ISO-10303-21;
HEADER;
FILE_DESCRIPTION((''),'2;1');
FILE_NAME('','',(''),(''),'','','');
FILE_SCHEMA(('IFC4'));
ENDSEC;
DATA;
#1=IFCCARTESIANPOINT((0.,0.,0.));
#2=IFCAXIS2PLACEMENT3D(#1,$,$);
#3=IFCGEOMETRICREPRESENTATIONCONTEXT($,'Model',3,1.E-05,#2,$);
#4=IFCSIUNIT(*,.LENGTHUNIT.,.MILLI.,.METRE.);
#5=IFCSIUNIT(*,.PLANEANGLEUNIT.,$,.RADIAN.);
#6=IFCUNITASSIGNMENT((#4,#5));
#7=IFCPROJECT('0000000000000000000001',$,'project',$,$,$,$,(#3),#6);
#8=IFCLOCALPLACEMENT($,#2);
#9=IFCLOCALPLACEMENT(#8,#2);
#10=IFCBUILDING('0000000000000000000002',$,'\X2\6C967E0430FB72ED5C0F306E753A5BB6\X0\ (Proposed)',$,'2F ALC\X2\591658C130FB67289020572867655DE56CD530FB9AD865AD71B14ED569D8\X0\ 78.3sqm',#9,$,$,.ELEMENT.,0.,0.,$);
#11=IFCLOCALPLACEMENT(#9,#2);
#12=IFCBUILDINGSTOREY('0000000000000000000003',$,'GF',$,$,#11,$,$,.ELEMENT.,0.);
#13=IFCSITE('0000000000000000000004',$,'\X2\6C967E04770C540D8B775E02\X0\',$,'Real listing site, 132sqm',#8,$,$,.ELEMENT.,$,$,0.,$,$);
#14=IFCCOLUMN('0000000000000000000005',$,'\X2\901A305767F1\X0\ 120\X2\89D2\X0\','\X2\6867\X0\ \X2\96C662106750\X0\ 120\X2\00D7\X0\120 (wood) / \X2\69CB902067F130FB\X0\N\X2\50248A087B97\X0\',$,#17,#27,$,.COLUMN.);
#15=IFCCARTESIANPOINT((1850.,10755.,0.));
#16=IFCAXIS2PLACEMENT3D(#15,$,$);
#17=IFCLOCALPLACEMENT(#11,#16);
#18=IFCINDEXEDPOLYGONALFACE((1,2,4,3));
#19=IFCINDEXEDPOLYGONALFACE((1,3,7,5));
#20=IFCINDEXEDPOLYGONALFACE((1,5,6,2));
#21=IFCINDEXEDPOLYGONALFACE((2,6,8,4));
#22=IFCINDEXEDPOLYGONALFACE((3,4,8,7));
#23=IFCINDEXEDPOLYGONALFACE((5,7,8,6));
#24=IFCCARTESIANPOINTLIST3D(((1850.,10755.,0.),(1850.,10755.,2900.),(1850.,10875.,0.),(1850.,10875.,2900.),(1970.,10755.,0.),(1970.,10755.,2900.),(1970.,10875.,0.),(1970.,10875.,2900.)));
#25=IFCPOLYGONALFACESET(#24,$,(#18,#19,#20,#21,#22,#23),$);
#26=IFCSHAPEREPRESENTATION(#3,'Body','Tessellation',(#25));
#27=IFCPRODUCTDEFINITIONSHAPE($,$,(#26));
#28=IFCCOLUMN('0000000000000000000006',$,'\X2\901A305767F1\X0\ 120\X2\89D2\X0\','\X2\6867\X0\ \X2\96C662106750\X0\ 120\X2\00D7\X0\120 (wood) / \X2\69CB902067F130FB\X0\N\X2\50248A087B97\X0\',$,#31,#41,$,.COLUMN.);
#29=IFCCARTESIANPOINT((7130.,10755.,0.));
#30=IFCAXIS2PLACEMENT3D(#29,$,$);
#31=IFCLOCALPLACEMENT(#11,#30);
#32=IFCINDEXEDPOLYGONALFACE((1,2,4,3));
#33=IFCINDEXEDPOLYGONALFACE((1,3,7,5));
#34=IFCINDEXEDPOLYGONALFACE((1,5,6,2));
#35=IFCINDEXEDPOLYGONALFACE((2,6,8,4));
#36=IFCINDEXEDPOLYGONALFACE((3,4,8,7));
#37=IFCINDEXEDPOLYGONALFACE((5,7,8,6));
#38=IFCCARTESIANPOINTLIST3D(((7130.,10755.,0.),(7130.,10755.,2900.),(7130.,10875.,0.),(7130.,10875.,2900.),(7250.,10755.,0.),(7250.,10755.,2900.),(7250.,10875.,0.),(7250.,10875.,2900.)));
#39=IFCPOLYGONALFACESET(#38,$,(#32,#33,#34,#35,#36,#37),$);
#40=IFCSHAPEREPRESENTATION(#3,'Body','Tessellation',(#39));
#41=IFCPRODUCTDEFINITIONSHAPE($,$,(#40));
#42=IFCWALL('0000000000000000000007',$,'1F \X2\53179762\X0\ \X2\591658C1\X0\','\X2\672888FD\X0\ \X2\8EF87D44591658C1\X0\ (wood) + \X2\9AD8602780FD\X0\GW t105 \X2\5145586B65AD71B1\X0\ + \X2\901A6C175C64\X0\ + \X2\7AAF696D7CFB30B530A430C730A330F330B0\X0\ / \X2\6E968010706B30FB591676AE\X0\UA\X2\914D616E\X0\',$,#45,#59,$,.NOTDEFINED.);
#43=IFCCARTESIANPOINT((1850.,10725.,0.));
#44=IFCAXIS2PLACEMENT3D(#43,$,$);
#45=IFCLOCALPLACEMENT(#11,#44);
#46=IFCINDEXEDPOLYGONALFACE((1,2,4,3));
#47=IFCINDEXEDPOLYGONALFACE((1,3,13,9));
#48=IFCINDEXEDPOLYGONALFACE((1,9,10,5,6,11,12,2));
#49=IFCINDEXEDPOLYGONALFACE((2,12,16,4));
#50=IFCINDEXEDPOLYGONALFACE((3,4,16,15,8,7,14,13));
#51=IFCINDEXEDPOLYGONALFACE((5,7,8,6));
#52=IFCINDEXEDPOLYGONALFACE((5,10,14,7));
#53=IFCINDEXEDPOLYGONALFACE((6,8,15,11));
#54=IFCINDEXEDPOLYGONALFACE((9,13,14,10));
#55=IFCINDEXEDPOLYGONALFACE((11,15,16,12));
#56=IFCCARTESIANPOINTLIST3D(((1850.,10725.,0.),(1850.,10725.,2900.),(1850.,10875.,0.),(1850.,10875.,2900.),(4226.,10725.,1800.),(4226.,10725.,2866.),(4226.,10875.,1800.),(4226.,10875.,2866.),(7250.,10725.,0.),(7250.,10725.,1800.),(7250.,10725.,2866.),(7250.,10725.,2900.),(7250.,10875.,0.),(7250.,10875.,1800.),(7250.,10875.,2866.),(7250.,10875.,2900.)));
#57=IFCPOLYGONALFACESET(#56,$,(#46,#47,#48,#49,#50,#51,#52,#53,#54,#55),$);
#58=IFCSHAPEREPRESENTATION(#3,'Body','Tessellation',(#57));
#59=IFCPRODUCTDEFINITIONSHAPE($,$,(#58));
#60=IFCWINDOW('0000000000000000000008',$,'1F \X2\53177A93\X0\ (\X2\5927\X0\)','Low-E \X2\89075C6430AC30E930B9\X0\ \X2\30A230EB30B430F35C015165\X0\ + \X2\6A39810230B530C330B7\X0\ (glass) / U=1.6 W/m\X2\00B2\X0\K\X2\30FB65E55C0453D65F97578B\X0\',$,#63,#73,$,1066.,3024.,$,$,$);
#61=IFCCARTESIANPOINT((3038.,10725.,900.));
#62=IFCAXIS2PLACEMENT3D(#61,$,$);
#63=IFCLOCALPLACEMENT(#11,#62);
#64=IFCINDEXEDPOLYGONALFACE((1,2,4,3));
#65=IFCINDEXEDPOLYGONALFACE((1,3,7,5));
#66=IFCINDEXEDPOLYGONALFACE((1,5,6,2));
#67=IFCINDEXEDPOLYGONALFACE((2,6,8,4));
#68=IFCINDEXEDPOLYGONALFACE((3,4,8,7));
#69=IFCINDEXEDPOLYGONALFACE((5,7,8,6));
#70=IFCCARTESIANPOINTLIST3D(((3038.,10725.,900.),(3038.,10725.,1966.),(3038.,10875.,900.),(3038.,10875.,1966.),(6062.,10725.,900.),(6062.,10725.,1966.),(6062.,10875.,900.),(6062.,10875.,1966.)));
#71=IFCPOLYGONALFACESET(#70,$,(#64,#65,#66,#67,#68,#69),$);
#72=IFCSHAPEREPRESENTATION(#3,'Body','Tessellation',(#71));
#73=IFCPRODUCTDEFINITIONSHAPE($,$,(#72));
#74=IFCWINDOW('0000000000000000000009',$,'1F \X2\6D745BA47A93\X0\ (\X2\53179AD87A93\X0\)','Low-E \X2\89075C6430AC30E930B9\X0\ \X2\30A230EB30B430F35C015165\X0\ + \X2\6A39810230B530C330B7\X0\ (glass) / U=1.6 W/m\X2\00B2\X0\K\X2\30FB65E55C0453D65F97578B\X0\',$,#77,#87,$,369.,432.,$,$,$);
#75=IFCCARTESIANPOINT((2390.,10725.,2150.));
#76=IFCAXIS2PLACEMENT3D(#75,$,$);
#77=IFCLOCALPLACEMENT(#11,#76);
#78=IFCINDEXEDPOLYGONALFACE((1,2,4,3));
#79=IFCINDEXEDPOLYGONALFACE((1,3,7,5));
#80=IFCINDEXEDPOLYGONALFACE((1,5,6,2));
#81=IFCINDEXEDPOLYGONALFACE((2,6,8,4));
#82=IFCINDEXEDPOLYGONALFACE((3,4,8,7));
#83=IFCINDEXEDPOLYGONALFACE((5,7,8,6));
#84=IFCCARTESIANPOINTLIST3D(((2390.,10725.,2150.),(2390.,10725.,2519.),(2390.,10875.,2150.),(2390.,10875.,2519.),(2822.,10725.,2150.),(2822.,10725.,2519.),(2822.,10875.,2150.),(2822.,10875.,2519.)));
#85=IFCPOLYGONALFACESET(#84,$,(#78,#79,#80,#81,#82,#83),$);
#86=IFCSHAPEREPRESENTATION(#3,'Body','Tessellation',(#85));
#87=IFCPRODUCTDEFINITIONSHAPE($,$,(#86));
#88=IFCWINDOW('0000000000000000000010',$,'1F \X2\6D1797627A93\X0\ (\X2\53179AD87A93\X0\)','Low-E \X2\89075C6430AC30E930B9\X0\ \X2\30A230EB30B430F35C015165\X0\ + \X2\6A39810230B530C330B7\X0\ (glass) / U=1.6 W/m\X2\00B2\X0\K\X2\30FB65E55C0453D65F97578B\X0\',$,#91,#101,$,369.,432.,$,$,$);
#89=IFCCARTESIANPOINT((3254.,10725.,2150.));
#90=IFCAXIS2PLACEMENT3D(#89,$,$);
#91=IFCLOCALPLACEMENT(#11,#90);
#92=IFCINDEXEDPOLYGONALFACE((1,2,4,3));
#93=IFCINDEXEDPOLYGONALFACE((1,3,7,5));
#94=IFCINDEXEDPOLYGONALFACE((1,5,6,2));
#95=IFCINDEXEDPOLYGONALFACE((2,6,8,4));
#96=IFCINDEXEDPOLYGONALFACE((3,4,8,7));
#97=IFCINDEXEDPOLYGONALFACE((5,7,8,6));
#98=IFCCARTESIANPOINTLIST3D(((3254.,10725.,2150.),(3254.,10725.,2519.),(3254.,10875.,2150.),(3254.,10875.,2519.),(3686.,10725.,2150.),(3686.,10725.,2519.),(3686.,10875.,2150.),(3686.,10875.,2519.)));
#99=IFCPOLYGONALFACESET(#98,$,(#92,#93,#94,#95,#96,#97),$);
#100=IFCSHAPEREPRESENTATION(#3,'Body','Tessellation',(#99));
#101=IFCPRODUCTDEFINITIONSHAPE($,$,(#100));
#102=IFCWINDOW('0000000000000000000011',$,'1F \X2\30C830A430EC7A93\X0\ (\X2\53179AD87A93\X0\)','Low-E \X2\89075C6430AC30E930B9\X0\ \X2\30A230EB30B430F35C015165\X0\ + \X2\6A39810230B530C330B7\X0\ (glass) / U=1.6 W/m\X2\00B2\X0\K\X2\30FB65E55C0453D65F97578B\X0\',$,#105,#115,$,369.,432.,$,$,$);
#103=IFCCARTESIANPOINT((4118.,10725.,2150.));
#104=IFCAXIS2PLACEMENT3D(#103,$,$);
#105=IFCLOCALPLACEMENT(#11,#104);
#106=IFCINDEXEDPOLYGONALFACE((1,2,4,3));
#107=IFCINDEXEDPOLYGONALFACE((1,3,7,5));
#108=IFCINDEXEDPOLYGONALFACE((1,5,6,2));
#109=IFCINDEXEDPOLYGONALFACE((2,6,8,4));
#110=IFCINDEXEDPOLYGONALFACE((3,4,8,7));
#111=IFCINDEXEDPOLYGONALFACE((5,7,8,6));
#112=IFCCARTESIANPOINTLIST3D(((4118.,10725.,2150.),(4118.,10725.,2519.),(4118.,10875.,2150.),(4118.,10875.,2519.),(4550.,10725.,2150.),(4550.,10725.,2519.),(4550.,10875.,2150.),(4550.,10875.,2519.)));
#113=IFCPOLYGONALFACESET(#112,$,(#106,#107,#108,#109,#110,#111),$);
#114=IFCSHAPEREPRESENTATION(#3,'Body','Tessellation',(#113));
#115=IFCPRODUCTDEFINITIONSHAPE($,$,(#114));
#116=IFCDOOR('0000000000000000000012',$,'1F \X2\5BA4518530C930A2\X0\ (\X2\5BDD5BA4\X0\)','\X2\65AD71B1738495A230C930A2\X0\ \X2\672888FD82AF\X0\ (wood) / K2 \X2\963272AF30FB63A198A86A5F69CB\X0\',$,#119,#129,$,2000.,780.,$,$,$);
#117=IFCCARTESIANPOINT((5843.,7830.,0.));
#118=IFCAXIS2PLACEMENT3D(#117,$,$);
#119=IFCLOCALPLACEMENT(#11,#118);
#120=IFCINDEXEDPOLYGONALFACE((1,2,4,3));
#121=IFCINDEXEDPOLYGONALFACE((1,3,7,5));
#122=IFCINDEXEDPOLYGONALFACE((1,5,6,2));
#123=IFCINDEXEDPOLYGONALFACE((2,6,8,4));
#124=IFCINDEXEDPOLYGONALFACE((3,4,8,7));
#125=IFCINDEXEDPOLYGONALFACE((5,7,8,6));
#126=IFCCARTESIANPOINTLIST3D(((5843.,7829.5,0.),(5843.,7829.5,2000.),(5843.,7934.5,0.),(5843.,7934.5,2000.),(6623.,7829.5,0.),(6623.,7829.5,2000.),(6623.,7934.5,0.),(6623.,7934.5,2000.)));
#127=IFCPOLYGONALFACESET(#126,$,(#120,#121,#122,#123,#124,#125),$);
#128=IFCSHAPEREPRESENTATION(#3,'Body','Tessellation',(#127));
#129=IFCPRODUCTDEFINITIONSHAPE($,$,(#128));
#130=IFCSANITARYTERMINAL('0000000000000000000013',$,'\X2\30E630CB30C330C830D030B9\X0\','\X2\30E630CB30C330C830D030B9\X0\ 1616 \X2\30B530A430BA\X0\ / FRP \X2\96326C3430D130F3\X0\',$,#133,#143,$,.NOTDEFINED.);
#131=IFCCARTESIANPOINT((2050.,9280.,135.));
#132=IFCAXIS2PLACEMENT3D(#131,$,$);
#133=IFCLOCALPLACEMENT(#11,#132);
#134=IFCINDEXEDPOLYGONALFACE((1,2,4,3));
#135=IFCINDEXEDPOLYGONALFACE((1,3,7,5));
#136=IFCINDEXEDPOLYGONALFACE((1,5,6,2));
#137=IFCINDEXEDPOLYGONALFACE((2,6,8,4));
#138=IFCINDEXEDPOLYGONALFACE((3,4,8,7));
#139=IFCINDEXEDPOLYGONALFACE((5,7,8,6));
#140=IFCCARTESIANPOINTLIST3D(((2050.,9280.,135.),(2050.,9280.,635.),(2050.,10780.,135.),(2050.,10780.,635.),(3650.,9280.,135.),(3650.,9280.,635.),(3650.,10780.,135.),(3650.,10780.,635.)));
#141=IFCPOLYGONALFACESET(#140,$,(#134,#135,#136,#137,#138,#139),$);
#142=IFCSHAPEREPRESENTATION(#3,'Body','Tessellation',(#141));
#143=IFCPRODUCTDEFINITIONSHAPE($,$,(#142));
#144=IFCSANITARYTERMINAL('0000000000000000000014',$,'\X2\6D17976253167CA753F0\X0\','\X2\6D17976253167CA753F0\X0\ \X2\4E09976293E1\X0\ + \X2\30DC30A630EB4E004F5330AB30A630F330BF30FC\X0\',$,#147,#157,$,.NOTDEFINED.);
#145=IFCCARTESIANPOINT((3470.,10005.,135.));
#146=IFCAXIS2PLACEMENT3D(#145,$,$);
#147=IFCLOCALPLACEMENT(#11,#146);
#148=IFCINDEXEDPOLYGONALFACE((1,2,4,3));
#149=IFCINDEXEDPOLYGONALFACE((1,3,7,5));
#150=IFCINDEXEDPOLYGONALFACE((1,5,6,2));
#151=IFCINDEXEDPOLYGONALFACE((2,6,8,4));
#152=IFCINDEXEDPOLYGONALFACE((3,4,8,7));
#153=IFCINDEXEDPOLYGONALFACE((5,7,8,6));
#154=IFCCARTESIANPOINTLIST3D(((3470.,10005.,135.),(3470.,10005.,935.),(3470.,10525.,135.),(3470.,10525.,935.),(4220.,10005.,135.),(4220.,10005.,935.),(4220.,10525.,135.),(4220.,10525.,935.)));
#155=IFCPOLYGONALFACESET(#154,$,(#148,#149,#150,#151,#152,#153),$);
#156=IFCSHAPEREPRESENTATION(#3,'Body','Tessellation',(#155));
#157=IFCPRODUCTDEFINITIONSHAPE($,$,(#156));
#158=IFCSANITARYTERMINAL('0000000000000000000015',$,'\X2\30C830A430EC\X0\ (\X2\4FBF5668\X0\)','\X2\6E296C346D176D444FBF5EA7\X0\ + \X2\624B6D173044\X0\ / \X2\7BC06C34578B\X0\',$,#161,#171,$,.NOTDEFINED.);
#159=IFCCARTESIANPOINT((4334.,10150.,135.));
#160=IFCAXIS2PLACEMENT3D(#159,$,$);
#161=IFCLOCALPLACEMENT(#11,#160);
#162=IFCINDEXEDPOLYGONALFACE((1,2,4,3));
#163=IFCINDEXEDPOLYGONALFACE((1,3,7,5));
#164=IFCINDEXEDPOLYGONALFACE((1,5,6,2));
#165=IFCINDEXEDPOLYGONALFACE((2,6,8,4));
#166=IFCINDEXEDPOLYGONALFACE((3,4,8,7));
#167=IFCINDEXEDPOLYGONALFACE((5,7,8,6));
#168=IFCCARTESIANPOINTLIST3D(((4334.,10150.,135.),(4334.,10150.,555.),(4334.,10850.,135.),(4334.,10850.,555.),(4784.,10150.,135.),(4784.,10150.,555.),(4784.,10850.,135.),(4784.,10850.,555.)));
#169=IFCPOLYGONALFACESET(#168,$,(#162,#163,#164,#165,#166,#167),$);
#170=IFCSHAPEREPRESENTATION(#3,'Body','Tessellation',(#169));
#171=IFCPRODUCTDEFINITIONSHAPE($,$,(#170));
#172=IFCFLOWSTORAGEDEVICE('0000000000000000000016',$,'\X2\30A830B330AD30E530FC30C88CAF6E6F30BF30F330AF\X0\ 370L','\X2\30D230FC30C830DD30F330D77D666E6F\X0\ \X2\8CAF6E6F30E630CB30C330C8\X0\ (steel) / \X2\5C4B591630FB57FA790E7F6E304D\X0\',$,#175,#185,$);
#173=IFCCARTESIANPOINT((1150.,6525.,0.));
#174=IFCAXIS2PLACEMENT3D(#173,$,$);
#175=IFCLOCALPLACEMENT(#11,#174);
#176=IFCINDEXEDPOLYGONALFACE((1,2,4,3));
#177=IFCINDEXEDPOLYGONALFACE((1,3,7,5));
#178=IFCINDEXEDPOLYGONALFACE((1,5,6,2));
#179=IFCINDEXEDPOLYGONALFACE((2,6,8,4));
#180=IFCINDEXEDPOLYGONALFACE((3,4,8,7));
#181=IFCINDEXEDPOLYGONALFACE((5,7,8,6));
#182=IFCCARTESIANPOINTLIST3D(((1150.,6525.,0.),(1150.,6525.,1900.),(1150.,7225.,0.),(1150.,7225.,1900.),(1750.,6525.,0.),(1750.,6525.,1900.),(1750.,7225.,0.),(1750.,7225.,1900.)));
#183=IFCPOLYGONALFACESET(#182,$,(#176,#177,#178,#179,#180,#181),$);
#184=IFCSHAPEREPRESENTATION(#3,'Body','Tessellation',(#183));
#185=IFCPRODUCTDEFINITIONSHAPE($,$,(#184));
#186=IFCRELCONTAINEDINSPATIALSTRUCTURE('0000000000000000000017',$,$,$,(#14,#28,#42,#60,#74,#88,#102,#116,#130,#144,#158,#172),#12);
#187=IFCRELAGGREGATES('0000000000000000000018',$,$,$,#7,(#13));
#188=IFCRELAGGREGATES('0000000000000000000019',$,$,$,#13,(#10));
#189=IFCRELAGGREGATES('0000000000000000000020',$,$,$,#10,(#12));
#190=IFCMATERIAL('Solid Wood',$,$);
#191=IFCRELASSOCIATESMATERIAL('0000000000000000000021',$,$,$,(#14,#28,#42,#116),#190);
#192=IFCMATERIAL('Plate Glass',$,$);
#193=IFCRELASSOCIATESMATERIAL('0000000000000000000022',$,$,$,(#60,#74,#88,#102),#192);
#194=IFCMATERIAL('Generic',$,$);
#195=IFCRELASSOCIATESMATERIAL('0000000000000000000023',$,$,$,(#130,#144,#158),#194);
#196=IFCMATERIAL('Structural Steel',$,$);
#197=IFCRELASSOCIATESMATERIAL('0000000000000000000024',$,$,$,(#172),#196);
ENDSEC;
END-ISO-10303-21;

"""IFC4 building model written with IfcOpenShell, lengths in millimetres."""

from ifc_helpers import new_model, si_unit, frame, frame_2d, origin, place, context, project, spatial, rectangle, extrude, material, element, fill, save


model = new_model("IFC4")

# Units and contexts
model_context = context("Model", 3, precision=1e-05, world=origin())
ifc_project = project(units=[si_unit("LENGTHUNIT", "METRE", prefix="MILLI"), si_unit("PLANEANGLEUNIT", "RADIAN")], contexts=[model_context])

# Site, building, storey
site_placement = place(None, origin())
site = spatial("IfcSite", under=ifc_project, at=site_placement, Name="沖縄県名護市", ObjectType="Real listing site, 132sqm", CompositionType="ELEMENT", RefElevation=0.0)
building_placement = place(site_placement, origin())
building = spatial("IfcBuilding", under=site, at=building_placement, Name="沖縄・狭小の町家 (Proposed)", ObjectType="2F ALC外壁・木造在来工法・高断熱仕様 78.3sqm", CompositionType="ELEMENT", ElevationOfRefHeight=0.0, ElevationOfTerrain=0.0)
storey_placement = place(building_placement, origin())
storey = spatial("IfcBuildingStorey", under=building, at=storey_placement, Name="GF", CompositionType="ELEMENT", Elevation=0.0)

# Columns
ifc_material_1 = material(Name="Solid Wood")
column_1_placement = place(storey_placement, frame((1850.0, 10755.0, 0.0)))
element("IfcColumn", 1, at=column_1_placement, inside=storey, material=ifc_material_1, Name="通し柱 120角", Description="桧 集成材 120×120 (wood) / 構造柱・N値計算", PredefinedType="COLUMN", context=model_context, shape_type="SweptSolid", body=[
    extrude(rectangle(XDim=120.0, YDim=120.0, at=frame_2d((60.0, 60.0))), frame((1850.0, 10755.0, 0.0)), (0.0, 0.0, 1.0), 2900.0),
])
column_2_placement = place(storey_placement, frame((7130.0, 10755.0, 0.0)))
element("IfcColumn", 2, at=column_2_placement, inside=storey, material=ifc_material_1, Name="通し柱 120角", Description="桧 集成材 120×120 (wood) / 構造柱・N値計算", PredefinedType="COLUMN", context=model_context, shape_type="SweptSolid", body=[
    extrude(rectangle(XDim=120.0, YDim=120.0, at=frame_2d((60.0, 60.0))), frame((7130.0, 10755.0, 0.0)), (0.0, 0.0, 1.0), 2900.0),
])

# Wall, openings, windows
wall_1_placement = place(storey_placement, frame((1850.0, 10725.0, 0.0)))
wall_1 = element("IfcWall", 3, at=wall_1_placement, inside=storey, material=ifc_material_1, Name="1F 北面 外壁", Description="木製 軸組外壁 (wood) + 高性能GW t105 充填断熱 + 通気層 + 窯業系サイディング / 準耐火・外皮UA配慮", PredefinedType="NOTDEFINED", context=model_context, shape_type="SweptSolid", body=[
    extrude(rectangle(XDim=5400.0, YDim=150.0, at=frame_2d((2700.0, 75.0))), frame((1850.0, 10725.0, 0.0)), (0.0, 0.0, 1.0), 2900.0),
])
opening_1_placement = place(storey_placement, frame((3038.0, 10725.0, 900.0)))
opening_1 = element("IfcOpeningElement", 4, at=opening_1_placement, cuts=wall_1, PredefinedType="NOTDEFINED", context=model_context, shape_type="SweptSolid", body=[
    extrude(rectangle(XDim=3024.0, YDim=150.0, at=frame_2d((1512.0, 75.0))), frame((3038.0, 10725.0, 900.0)), (0.0, 0.0, 1.0), 1066.0),
])
opening_2_placement = place(storey_placement, frame((2390.0, 10725.0, 2150.0)))
opening_2 = element("IfcOpeningElement", 5, at=opening_2_placement, cuts=wall_1, PredefinedType="NOTDEFINED", context=model_context, shape_type="SweptSolid", body=[
    extrude(rectangle(XDim=432.0, YDim=150.0, at=frame_2d((216.0, 75.0))), frame((2390.0, 10725.0, 2150.0)), (0.0, 0.0, 1.0), 369.0),
])
opening_3_placement = place(storey_placement, frame((3254.0, 10725.0, 2150.0)))
opening_3 = element("IfcOpeningElement", 6, at=opening_3_placement, cuts=wall_1, PredefinedType="NOTDEFINED", context=model_context, shape_type="SweptSolid", body=[
    extrude(rectangle(XDim=432.0, YDim=150.0, at=frame_2d((216.0, 75.0))), frame((3254.0, 10725.0, 2150.0)), (0.0, 0.0, 1.0), 369.0),
])
opening_4_placement = place(storey_placement, frame((4118.0, 10725.0, 2150.0)))
opening_4 = element("IfcOpeningElement", 7, at=opening_4_placement, cuts=wall_1, PredefinedType="NOTDEFINED", context=model_context, shape_type="SweptSolid", body=[
    extrude(rectangle(XDim=432.0, YDim=150.0, at=frame_2d((216.0, 75.0))), frame((4118.0, 10725.0, 2150.0)), (0.0, 0.0, 1.0), 369.0),
])
ifc_material_2 = material(Name="Plate Glass")
window_1_placement = place(storey_placement, frame((3038.0, 10725.0, 900.0)))
window_1 = element("IfcWindow", 8, at=window_1_placement, inside=storey, material=ifc_material_2, Name="1F 北窓 (大)", Description="Low-E 複層ガラス アルゴン封入 + 樹脂サッシ (glass) / U=1.6 W/m²K・日射取得型", OverallHeight=1066.0, OverallWidth=3024.0, context=model_context, shape_type="SweptSolid", body=[
    extrude(rectangle(XDim=3024.0, YDim=150.0, at=frame_2d((1512.0, 75.0))), frame((3038.0, 10725.0, 900.0)), (0.0, 0.0, 1.0), 1066.0),
])
fill(opening_1, window_1)
window_2_placement = place(storey_placement, frame((2390.0, 10725.0, 2150.0)))
window_2 = element("IfcWindow", 9, at=window_2_placement, inside=storey, material=ifc_material_2, Name="1F 浴室窓 (北高窓)", Description="Low-E 複層ガラス アルゴン封入 + 樹脂サッシ (glass) / U=1.6 W/m²K・日射取得型", OverallHeight=369.0, OverallWidth=432.0, context=model_context, shape_type="SweptSolid", body=[
    extrude(rectangle(XDim=432.0, YDim=150.0, at=frame_2d((216.0, 75.0))), frame((2390.0, 10725.0, 2150.0)), (0.0, 0.0, 1.0), 369.0),
])
fill(opening_2, window_2)
window_3_placement = place(storey_placement, frame((3254.0, 10725.0, 2150.0)))
window_3 = element("IfcWindow", 10, at=window_3_placement, inside=storey, material=ifc_material_2, Name="1F 洗面窓 (北高窓)", Description="Low-E 複層ガラス アルゴン封入 + 樹脂サッシ (glass) / U=1.6 W/m²K・日射取得型", OverallHeight=369.0, OverallWidth=432.0, context=model_context, shape_type="SweptSolid", body=[
    extrude(rectangle(XDim=432.0, YDim=150.0, at=frame_2d((216.0, 75.0))), frame((3254.0, 10725.0, 2150.0)), (0.0, 0.0, 1.0), 369.0),
])
fill(opening_3, window_3)
window_4_placement = place(storey_placement, frame((4118.0, 10725.0, 2150.0)))
window_4 = element("IfcWindow", 11, at=window_4_placement, inside=storey, material=ifc_material_2, Name="1F トイレ窓 (北高窓)", Description="Low-E 複層ガラス アルゴン封入 + 樹脂サッシ (glass) / U=1.6 W/m²K・日射取得型", OverallHeight=369.0, OverallWidth=432.0, context=model_context, shape_type="SweptSolid", body=[
    extrude(rectangle(XDim=432.0, YDim=150.0, at=frame_2d((216.0, 75.0))), frame((4118.0, 10725.0, 2150.0)), (0.0, 0.0, 1.0), 369.0),
])
fill(opening_4, window_4)

# Door
door_1_placement = place(storey_placement, frame((5843.0, 7830.0, 0.0)))
element("IfcDoor", 12, at=door_1_placement, inside=storey, material=ifc_material_1, Name="1F 室内ドア (寝室)", Description="断熱玄関ドア 木製芯 (wood) / K2 防犯・採風機構", OverallHeight=2000.0, OverallWidth=780.0, context=model_context, shape_type="SweptSolid", body=[
    extrude(rectangle(XDim=780.0, YDim=105.0, at=frame_2d((390.0, 52.0))), frame((5843.0, 7830.0, 0.0)), (0.0, 0.0, 1.0), 2000.0),
])

# Sanitary terminals
ifc_material_3 = material(Name="Generic")
sanitary_terminal_1_placement = place(storey_placement, frame((2050.0, 9280.0, 135.0)))
element("IfcSanitaryTerminal", 13, at=sanitary_terminal_1_placement, inside=storey, material=ifc_material_3, Name="ユニットバス", Description="ユニットバス 1616 サイズ / FRP 防水パン", PredefinedType="NOTDEFINED", context=model_context, shape_type="SweptSolid", body=[
    extrude(rectangle(XDim=1600.0, YDim=1500.0, at=frame_2d((800.0, 750.0))), frame((2050.0, 9280.0, 135.0)), (0.0, 0.0, 1.0), 500.0),
])
sanitary_terminal_2_placement = place(storey_placement, frame((3470.0, 10005.0, 135.0)))
element("IfcSanitaryTerminal", 14, at=sanitary_terminal_2_placement, inside=storey, material=ifc_material_3, Name="洗面化粧台", Description="洗面化粧台 三面鏡 + ボウル一体カウンター", PredefinedType="NOTDEFINED", context=model_context, shape_type="SweptSolid", body=[
    extrude(rectangle(XDim=750.0, YDim=520.0, at=frame_2d((375.0, 260.0))), frame((3470.0, 10005.0, 135.0)), (0.0, 0.0, 1.0), 800.0),
])
sanitary_terminal_3_placement = place(storey_placement, frame((4334.0, 10150.0, 135.0)))
element("IfcSanitaryTerminal", 15, at=sanitary_terminal_3_placement, inside=storey, material=ifc_material_3, Name="トイレ (便器)", Description="温水洗浄便座 + 手洗い / 節水型", PredefinedType="NOTDEFINED", context=model_context, shape_type="SweptSolid", body=[
    extrude(rectangle(XDim=450.0, YDim=700.0, at=frame_2d((225.0, 350.0))), frame((4334.0, 10150.0, 135.0)), (0.0, 0.0, 1.0), 420.0),
])

# Flow storage device
ifc_material_4 = material(Name="Structural Steel")
flow_storage_device_placement = place(storey_placement, frame((1150.0, 6525.0, 0.0)))
element("IfcFlowStorageDevice", 16, at=flow_storage_device_placement, inside=storey, material=ifc_material_4, Name="エコキュート貯湯タンク 370L", Description="ヒートポンプ給湯 貯湯ユニット (steel) / 屋外・基礎置き", context=model_context, shape_type="SweptSolid", body=[
    extrude(rectangle(XDim=600.0, YDim=700.0, at=frame_2d((300.0, 350.0))), frame((1150.0, 6525.0, 0.0)), (0.0, 0.0, 1.0), 1900.0),
])

save(model, "model.ifc")
